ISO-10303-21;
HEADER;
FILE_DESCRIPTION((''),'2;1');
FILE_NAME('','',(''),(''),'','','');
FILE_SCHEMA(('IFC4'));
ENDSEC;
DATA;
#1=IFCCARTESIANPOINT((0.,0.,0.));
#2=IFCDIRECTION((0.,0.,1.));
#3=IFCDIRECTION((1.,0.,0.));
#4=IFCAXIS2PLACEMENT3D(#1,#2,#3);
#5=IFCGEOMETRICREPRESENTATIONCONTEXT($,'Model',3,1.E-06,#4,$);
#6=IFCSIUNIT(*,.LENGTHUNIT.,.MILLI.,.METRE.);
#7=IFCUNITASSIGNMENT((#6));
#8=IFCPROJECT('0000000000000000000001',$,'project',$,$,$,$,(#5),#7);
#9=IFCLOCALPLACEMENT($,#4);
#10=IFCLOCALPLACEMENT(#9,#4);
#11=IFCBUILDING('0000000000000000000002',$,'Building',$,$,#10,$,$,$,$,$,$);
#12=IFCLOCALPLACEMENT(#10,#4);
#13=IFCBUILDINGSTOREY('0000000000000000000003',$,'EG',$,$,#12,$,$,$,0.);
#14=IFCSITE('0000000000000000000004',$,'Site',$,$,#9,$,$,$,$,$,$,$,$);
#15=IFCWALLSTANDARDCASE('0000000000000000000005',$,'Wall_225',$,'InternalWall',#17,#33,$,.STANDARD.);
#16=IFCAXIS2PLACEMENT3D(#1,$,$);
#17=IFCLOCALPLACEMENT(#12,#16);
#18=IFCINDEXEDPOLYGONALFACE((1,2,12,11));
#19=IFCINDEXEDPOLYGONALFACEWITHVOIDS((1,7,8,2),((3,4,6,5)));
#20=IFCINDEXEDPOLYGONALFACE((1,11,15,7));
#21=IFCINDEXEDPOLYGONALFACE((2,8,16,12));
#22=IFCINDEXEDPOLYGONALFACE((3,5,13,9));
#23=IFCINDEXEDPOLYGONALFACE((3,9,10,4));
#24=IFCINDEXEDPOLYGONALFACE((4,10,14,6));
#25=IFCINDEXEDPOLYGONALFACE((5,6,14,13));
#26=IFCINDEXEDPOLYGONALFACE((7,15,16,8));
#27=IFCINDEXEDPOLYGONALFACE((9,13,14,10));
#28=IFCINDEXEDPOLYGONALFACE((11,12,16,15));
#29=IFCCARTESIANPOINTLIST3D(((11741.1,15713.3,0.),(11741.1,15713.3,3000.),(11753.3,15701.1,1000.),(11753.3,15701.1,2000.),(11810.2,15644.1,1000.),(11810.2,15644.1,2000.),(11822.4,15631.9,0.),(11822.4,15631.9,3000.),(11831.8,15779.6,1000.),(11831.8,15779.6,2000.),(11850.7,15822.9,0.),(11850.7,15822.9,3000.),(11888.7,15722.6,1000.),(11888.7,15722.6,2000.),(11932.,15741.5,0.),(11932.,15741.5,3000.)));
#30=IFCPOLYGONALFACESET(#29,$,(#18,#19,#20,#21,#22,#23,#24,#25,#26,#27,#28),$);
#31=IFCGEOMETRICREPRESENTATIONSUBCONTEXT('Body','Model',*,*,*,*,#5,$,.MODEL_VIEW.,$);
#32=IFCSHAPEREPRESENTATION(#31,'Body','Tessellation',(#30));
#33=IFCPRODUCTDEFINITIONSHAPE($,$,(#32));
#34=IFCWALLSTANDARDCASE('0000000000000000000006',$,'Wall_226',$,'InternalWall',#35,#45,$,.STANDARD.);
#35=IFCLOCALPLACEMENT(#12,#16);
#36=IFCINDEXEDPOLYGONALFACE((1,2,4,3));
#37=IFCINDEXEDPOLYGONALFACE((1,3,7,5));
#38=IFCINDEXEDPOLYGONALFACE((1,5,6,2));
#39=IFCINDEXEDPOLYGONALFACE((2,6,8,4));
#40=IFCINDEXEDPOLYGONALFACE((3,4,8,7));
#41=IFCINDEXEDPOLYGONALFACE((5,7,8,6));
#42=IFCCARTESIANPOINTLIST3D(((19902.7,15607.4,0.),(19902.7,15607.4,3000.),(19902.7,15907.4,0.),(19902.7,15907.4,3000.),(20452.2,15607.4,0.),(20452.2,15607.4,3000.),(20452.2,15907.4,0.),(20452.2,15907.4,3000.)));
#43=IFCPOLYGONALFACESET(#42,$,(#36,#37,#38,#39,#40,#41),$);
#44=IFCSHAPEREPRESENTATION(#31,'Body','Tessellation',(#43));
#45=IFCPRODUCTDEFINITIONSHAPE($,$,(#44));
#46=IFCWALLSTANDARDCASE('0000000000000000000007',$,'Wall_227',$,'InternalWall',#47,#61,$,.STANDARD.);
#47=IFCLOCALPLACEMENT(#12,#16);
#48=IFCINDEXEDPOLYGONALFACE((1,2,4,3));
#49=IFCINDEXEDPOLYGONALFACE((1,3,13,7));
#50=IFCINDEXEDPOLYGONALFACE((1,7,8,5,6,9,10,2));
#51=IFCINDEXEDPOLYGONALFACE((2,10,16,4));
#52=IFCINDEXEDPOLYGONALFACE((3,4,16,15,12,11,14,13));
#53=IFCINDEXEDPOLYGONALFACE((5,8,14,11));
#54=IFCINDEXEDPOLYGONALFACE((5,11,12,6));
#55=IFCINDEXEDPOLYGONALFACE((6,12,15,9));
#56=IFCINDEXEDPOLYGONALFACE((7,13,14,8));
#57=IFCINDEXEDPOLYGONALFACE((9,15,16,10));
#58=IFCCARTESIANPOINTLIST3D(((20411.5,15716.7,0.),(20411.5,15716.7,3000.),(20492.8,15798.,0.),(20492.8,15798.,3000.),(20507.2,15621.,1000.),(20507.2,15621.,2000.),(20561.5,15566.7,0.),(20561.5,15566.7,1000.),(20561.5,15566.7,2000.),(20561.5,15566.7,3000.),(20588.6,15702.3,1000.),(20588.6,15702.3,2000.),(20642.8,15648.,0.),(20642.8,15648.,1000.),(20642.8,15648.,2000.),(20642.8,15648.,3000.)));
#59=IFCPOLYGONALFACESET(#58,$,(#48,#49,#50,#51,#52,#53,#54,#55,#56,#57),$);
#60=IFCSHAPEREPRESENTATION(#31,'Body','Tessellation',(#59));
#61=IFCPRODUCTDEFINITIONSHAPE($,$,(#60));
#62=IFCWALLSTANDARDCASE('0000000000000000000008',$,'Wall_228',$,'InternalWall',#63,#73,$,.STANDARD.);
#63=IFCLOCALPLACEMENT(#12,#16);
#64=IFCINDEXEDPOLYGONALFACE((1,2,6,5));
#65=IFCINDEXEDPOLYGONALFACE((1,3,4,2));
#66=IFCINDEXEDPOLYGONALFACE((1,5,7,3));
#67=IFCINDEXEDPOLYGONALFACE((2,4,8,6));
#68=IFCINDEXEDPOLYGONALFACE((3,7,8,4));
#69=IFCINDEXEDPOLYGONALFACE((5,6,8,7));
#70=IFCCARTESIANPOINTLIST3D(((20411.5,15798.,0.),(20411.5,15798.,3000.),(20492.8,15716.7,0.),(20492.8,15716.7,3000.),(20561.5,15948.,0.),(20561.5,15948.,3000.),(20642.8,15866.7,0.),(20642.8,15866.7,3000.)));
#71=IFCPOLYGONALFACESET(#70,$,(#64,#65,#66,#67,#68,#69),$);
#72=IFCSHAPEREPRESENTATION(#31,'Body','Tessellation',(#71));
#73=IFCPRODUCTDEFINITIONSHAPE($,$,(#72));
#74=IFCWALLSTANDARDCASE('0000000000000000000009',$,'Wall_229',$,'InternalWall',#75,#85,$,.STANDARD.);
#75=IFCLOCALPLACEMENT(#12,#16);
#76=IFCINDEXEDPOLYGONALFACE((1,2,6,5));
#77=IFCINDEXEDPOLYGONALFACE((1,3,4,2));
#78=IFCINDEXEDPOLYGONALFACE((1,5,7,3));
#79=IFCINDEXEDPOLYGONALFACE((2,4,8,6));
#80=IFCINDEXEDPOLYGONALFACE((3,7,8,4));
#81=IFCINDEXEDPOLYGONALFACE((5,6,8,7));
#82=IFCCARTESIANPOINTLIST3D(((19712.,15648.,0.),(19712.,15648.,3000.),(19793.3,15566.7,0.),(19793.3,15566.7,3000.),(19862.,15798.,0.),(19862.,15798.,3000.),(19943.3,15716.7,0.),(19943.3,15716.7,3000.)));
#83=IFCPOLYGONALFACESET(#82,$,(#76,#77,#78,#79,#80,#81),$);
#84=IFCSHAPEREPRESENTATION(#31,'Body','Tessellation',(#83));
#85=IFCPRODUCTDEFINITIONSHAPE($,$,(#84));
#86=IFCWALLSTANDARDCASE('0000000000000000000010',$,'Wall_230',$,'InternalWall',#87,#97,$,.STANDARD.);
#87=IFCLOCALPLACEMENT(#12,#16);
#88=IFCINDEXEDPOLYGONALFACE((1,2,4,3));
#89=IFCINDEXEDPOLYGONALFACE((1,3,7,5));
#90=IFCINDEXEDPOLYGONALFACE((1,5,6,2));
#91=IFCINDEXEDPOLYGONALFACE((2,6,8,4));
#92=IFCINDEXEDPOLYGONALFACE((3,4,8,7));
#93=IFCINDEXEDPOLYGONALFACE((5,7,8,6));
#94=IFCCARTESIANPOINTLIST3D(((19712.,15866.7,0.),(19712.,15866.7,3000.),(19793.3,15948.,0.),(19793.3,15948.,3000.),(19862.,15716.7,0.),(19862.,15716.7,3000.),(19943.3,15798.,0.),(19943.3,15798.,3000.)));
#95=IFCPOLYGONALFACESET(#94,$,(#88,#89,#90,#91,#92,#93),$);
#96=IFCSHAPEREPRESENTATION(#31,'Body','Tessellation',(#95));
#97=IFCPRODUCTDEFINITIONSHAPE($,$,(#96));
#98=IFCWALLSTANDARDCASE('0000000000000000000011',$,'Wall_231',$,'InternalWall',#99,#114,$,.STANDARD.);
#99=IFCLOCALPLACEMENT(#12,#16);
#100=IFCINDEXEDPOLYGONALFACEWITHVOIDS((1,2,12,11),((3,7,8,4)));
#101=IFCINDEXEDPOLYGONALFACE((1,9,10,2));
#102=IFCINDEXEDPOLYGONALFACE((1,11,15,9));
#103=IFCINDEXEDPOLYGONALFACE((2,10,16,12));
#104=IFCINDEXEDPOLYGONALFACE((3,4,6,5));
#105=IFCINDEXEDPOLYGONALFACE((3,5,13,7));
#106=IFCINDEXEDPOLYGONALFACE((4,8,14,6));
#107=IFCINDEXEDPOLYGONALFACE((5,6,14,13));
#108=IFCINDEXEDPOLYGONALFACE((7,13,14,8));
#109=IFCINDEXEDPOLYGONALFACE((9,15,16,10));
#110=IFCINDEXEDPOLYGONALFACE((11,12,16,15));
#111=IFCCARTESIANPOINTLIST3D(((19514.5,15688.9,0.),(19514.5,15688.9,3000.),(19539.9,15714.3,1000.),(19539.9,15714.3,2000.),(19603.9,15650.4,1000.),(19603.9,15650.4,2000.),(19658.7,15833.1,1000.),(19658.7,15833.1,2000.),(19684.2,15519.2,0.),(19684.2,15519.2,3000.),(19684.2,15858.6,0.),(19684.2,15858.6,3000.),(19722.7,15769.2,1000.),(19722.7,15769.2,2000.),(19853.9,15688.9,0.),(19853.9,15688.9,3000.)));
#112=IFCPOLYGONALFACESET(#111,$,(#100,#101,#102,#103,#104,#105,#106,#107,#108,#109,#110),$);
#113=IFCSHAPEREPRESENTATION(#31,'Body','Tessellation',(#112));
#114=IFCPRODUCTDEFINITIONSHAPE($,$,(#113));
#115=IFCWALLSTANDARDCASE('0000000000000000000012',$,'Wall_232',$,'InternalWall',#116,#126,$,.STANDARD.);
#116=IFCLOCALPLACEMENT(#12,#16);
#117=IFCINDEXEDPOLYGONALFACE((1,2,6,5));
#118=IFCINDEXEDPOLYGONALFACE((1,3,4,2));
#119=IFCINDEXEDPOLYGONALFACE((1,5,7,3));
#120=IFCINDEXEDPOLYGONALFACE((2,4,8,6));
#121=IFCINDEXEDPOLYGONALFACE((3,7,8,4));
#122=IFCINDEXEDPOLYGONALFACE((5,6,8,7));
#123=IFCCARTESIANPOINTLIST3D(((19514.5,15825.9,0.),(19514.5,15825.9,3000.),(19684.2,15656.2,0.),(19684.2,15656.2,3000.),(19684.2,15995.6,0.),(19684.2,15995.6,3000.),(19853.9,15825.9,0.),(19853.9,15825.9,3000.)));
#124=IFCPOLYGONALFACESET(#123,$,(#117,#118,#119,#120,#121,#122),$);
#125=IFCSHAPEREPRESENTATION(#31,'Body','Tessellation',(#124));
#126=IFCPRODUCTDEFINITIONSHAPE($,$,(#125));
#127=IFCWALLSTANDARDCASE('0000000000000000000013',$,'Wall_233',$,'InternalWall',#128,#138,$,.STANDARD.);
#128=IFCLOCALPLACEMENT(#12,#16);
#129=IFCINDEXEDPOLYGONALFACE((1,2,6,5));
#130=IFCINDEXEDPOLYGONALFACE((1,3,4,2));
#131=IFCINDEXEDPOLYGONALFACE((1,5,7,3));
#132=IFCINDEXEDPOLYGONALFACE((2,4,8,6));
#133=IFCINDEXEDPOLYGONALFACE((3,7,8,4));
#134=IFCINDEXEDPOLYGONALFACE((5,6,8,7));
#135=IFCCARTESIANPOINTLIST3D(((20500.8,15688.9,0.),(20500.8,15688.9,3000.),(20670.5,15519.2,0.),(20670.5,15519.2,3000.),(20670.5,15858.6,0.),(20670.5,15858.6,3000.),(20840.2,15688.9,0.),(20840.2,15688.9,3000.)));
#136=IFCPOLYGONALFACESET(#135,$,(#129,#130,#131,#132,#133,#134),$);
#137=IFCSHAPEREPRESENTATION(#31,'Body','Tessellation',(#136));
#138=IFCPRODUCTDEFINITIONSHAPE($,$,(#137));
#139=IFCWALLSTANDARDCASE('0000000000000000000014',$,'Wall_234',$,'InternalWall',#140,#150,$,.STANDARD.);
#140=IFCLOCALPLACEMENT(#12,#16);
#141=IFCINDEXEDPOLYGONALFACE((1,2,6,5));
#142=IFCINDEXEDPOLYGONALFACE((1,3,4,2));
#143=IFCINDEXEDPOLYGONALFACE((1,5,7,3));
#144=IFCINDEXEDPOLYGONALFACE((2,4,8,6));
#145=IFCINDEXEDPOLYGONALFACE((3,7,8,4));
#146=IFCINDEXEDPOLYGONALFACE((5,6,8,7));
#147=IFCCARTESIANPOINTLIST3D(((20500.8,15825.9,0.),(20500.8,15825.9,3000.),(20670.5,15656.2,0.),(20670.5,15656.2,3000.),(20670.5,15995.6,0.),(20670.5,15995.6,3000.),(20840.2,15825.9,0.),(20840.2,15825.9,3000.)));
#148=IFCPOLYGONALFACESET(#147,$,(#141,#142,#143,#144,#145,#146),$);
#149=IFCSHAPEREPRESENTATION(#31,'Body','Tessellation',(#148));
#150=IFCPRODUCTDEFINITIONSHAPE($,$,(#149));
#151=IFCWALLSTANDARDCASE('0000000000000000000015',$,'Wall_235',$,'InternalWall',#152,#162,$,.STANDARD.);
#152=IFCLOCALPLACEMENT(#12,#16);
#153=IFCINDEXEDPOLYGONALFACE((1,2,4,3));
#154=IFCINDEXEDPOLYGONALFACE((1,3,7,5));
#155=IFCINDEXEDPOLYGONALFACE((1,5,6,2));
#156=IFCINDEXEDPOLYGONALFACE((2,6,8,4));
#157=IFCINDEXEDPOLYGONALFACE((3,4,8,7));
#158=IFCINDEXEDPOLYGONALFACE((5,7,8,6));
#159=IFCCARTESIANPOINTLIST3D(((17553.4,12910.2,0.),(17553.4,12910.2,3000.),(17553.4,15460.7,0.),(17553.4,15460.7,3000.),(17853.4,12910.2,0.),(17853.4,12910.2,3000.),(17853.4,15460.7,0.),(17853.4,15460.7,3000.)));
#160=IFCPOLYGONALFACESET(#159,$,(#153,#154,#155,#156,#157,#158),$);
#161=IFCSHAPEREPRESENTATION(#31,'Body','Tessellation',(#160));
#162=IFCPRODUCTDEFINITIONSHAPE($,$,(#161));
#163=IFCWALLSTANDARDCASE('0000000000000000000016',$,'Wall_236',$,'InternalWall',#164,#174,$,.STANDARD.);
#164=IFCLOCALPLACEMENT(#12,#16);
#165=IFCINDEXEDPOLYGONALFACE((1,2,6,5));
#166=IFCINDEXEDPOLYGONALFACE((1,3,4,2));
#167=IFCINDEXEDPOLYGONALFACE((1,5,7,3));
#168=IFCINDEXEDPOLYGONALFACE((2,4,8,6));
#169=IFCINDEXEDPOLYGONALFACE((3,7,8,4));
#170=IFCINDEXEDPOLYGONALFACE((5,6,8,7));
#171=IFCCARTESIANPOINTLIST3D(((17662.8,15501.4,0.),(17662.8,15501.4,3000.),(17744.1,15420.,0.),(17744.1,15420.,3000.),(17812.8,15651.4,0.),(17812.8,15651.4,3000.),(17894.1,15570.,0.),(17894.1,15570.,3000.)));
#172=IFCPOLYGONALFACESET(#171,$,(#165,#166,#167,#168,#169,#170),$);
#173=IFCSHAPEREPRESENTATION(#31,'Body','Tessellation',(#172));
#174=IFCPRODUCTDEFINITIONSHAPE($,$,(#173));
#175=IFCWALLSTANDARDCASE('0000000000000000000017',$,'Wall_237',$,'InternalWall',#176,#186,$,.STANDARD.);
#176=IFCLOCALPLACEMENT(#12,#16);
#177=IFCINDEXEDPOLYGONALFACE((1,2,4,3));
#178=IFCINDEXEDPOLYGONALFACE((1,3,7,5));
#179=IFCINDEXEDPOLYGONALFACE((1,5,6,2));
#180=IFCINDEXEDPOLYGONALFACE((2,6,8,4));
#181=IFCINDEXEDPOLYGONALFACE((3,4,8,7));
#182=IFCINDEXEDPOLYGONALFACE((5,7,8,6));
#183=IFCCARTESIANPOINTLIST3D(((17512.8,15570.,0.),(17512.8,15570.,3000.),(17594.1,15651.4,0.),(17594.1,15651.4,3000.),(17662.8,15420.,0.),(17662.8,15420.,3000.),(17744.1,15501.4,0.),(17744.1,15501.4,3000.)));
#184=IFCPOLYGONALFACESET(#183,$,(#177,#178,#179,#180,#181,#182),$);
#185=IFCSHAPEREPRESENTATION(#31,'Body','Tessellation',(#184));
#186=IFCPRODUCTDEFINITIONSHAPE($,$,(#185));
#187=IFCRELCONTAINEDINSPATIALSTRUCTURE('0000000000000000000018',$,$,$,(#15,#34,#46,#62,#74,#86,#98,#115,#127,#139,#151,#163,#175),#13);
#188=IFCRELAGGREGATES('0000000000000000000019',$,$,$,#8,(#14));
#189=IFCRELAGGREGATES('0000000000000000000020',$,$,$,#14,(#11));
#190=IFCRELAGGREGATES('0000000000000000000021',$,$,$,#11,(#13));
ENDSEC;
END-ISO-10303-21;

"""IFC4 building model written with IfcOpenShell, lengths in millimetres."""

from ifc_helpers import new_model, si_unit, frame, origin_with_axes, place, context, subcontext, project, spatial, rectangle, extrude, element, save


model = new_model("IFC4")

# Units and contexts
model_context = context("Model", 3, precision=1e-06, world=origin_with_axes())
body_context = subcontext(model_context, "Body", "Model", "MODEL_VIEW")
ifc_project = project(units=[si_unit("LENGTHUNIT", "METRE", prefix="MILLI")], contexts=[model_context])

# Site, building, storey
site_placement = place(None, origin_with_axes())
site = spatial("IfcSite", under=ifc_project, at=site_placement, Name="Site")
building_placement = place(site_placement, origin_with_axes())
building = spatial("IfcBuilding", under=site, at=building_placement, Name="Building")
storey_placement = place(building_placement, origin_with_axes())
storey = spatial("IfcBuildingStorey", under=building, at=storey_placement, Name="EG", Elevation=0.0)

# Wall, opening
wall_1_placement = place(storey_placement, origin_with_axes())
wall_1 = element("IfcWallStandardCase", 1, at=wall_1_placement, inside=storey, Name="Wall_225", ObjectType="InternalWall", PredefinedType="STANDARD", context=body_context, shape_type="SweptSolid", body=[
    extrude(rectangle(XDim=155.0, YDim=115.0), frame((11836.6, 15727.4, 0.0), z_axis=(0.0, 0.0, 1.0), x_axis=(0.707107, 0.707107, 0.0)), (0.0, 0.0, 1.0), 3000.0),
])
opening_1_placement = place(wall_1_placement, origin_with_axes())
element("IfcOpeningElement", 2, at=opening_1_placement, inside=storey, cuts=wall_1, context=body_context, shape_type="SweptSolid", body=[
    extrude(rectangle(XDim=1121.9, YDim=80.5), frame((11463.6, 15354.5, 1000.0), z_axis=(0.0, 0.0, 1.0), x_axis=(0.707107, 0.707107, 0.0)), (0.0, 0.0, 1.0), 1000.0),
])

# Wall
wall_2_placement = place(storey_placement, origin_with_axes())
element("IfcWallStandardCase", 3, at=wall_2_placement, inside=storey, Name="Wall_226", ObjectType="InternalWall", PredefinedType="STANDARD", context=body_context, shape_type="SweptSolid", body=[
    extrude(rectangle(XDim=549.5, YDim=300.0), frame((20177.4, 15757.4, 0.0), z_axis=(0.0, 0.0, 1.0), x_axis=(-1.0, 0.0, 0.0)), (0.0, 0.0, 1.0), 3000.0),
])

# Wall, opening
wall_3_placement = place(storey_placement, origin_with_axes())
wall_3 = element("IfcWallStandardCase", 4, at=wall_3_placement, inside=storey, Name="Wall_227", ObjectType="InternalWall", PredefinedType="STANDARD", context=body_context, shape_type="SweptSolid", body=[
    extrude(rectangle(XDim=212.1, YDim=115.0), frame((20527.2, 15682.4, 0.0), z_axis=(0.0, 0.0, 1.0), x_axis=(0.707107, -0.707107, 0.0)), (0.0, 0.0, 1.0), 3000.0),
])
opening_2_placement = place(wall_3_placement, origin_with_axes())
element("IfcOpeningElement", 5, at=opening_2_placement, inside=storey, cuts=wall_3, context=body_context, shape_type="SweptSolid", body=[
    extrude(rectangle(XDim=2026.7, YDim=115.0), frame((21264.4, 14945.1, 1000.0), z_axis=(0.0, 0.0, 1.0), x_axis=(0.707107, -0.707107, 0.0)), (0.0, 0.0, 1.0), 1000.0),
])

# Walls
wall_4_placement = place(storey_placement, origin_with_axes())
element("IfcWallStandardCase", 6, at=wall_4_placement, inside=storey, Name="Wall_228", ObjectType="InternalWall", PredefinedType="STANDARD", context=body_context, shape_type="SweptSolid", body=[
    extrude(rectangle(XDim=212.1, YDim=115.0), frame((20527.2, 15832.4, 0.0), z_axis=(0.0, 0.0, 1.0), x_axis=(0.707107, 0.707107, 0.0)), (0.0, 0.0, 1.0), 3000.0),
])
wall_5_placement = place(storey_placement, origin_with_axes())
element("IfcWallStandardCase", 7, at=wall_5_placement, inside=storey, Name="Wall_229", ObjectType="InternalWall", PredefinedType="STANDARD", context=body_context, shape_type="SweptSolid", body=[
    extrude(rectangle(XDim=212.1, YDim=115.0), frame((19827.7, 15682.4, 0.0), z_axis=(0.0, 0.0, 1.0), x_axis=(-0.707107, -0.707107, 0.0)), (0.0, 0.0, 1.0), 3000.0),
])
wall_6_placement = place(storey_placement, origin_with_axes())
element("IfcWallStandardCase", 8, at=wall_6_placement, inside=storey, Name="Wall_230", ObjectType="InternalWall", PredefinedType="STANDARD", context=body_context, shape_type="SweptSolid", body=[
    extrude(rectangle(XDim=212.1, YDim=115.0), frame((19827.7, 15832.4, 0.0), z_axis=(0.0, 0.0, 1.0), x_axis=(-0.707107, 0.707107, 0.0)), (0.0, 0.0, 1.0), 3000.0),
])

# Wall, opening
wall_7_placement = place(storey_placement, origin_with_axes())
wall_7 = element("IfcWallStandardCase", 9, at=wall_7_placement, inside=storey, Name="Wall_231", ObjectType="InternalWall", PredefinedType="STANDARD", context=body_context, shape_type="SweptSolid", body=[
    extrude(rectangle(XDim=240.0, YDim=240.0), frame((19684.2, 15688.9, 0.0), z_axis=(0.0, 0.0, 1.0), x_axis=(-0.707107, 0.707107, 0.0)), (0.0, 0.0, 1.0), 3000.0),
])
opening_3_placement = place(wall_7_placement, origin_with_axes())
element("IfcOpeningElement", 10, at=opening_3_placement, inside=storey, cuts=wall_7, context=body_context, shape_type="SweptSolid", body=[
    extrude(rectangle(XDim=1085.7, YDim=168.0), frame((19279.4, 16093.6, 1000.0), z_axis=(0.0, 0.0, 1.0), x_axis=(-0.707107, 0.707107, 0.0)), (0.0, 0.0, 1.0), 1000.0),
])

# Walls
wall_8_placement = place(storey_placement, origin_with_axes())
element("IfcWallStandardCase", 11, at=wall_8_placement, inside=storey, Name="Wall_232", ObjectType="InternalWall", PredefinedType="STANDARD", context=body_context, shape_type="SweptSolid", body=[
    extrude(rectangle(XDim=240.0, YDim=240.0), frame((19684.2, 15825.9, 0.0), z_axis=(0.0, 0.0, 1.0), x_axis=(0.707107, 0.707107, 0.0)), (0.0, 0.0, 1.0), 3000.0),
])
wall_9_placement = place(storey_placement, origin_with_axes())
element("IfcWallStandardCase", 12, at=wall_9_placement, inside=storey, Name="Wall_233", ObjectType="InternalWall", PredefinedType="STANDARD", context=body_context, shape_type="SweptSolid", body=[
    extrude(rectangle(XDim=240.0, YDim=240.0), frame((20670.5, 15688.9, 0.0), z_axis=(0.0, 0.0, 1.0), x_axis=(-0.707107, -0.707107, 0.0)), (0.0, 0.0, 1.0), 3000.0),
])
wall_10_placement = place(storey_placement, origin_with_axes())
element("IfcWallStandardCase", 13, at=wall_10_placement, inside=storey, Name="Wall_234", ObjectType="InternalWall", PredefinedType="STANDARD", context=body_context, shape_type="SweptSolid", body=[
    extrude(rectangle(XDim=240.0, YDim=240.0), frame((20670.5, 15825.9, 0.0), z_axis=(0.0, 0.0, 1.0), x_axis=(-0.707107, 0.707107, 0.0)), (0.0, 0.0, 1.0), 3000.0),
])
wall_11_placement = place(storey_placement, origin_with_axes())
element("IfcWallStandardCase", 14, at=wall_11_placement, inside=storey, Name="Wall_235", ObjectType="InternalWall", PredefinedType="STANDARD", context=body_context, shape_type="SweptSolid", body=[
    extrude(rectangle(XDim=2550.5, YDim=300.0), frame((17703.4, 14185.4, 0.0), z_axis=(0.0, 0.0, 1.0), x_axis=(0.0, -1.0, 0.0)), (0.0, 0.0, 1.0), 3000.0),
])
wall_12_placement = place(storey_placement, origin_with_axes())
element("IfcWallStandardCase", 15, at=wall_12_placement, inside=storey, Name="Wall_236", ObjectType="InternalWall", PredefinedType="STANDARD", context=body_context, shape_type="SweptSolid", body=[
    extrude(rectangle(XDim=212.1, YDim=115.0), frame((17778.4, 15535.7, 0.0), z_axis=(0.0, 0.0, 1.0), x_axis=(-0.707107, -0.707107, 0.0)), (0.0, 0.0, 1.0), 3000.0),
])
wall_13_placement = place(storey_placement, origin_with_axes())
element("IfcWallStandardCase", 16, at=wall_13_placement, inside=storey, Name="Wall_237", ObjectType="InternalWall", PredefinedType="STANDARD", context=body_context, shape_type="SweptSolid", body=[
    extrude(rectangle(XDim=212.1, YDim=115.0), frame((17628.4, 15535.7, 0.0), z_axis=(0.0, 0.0, 1.0), x_axis=(-0.707107, 0.707107, 0.0)), (0.0, 0.0, 1.0), 3000.0),
])

save(model, "model.ifc")
